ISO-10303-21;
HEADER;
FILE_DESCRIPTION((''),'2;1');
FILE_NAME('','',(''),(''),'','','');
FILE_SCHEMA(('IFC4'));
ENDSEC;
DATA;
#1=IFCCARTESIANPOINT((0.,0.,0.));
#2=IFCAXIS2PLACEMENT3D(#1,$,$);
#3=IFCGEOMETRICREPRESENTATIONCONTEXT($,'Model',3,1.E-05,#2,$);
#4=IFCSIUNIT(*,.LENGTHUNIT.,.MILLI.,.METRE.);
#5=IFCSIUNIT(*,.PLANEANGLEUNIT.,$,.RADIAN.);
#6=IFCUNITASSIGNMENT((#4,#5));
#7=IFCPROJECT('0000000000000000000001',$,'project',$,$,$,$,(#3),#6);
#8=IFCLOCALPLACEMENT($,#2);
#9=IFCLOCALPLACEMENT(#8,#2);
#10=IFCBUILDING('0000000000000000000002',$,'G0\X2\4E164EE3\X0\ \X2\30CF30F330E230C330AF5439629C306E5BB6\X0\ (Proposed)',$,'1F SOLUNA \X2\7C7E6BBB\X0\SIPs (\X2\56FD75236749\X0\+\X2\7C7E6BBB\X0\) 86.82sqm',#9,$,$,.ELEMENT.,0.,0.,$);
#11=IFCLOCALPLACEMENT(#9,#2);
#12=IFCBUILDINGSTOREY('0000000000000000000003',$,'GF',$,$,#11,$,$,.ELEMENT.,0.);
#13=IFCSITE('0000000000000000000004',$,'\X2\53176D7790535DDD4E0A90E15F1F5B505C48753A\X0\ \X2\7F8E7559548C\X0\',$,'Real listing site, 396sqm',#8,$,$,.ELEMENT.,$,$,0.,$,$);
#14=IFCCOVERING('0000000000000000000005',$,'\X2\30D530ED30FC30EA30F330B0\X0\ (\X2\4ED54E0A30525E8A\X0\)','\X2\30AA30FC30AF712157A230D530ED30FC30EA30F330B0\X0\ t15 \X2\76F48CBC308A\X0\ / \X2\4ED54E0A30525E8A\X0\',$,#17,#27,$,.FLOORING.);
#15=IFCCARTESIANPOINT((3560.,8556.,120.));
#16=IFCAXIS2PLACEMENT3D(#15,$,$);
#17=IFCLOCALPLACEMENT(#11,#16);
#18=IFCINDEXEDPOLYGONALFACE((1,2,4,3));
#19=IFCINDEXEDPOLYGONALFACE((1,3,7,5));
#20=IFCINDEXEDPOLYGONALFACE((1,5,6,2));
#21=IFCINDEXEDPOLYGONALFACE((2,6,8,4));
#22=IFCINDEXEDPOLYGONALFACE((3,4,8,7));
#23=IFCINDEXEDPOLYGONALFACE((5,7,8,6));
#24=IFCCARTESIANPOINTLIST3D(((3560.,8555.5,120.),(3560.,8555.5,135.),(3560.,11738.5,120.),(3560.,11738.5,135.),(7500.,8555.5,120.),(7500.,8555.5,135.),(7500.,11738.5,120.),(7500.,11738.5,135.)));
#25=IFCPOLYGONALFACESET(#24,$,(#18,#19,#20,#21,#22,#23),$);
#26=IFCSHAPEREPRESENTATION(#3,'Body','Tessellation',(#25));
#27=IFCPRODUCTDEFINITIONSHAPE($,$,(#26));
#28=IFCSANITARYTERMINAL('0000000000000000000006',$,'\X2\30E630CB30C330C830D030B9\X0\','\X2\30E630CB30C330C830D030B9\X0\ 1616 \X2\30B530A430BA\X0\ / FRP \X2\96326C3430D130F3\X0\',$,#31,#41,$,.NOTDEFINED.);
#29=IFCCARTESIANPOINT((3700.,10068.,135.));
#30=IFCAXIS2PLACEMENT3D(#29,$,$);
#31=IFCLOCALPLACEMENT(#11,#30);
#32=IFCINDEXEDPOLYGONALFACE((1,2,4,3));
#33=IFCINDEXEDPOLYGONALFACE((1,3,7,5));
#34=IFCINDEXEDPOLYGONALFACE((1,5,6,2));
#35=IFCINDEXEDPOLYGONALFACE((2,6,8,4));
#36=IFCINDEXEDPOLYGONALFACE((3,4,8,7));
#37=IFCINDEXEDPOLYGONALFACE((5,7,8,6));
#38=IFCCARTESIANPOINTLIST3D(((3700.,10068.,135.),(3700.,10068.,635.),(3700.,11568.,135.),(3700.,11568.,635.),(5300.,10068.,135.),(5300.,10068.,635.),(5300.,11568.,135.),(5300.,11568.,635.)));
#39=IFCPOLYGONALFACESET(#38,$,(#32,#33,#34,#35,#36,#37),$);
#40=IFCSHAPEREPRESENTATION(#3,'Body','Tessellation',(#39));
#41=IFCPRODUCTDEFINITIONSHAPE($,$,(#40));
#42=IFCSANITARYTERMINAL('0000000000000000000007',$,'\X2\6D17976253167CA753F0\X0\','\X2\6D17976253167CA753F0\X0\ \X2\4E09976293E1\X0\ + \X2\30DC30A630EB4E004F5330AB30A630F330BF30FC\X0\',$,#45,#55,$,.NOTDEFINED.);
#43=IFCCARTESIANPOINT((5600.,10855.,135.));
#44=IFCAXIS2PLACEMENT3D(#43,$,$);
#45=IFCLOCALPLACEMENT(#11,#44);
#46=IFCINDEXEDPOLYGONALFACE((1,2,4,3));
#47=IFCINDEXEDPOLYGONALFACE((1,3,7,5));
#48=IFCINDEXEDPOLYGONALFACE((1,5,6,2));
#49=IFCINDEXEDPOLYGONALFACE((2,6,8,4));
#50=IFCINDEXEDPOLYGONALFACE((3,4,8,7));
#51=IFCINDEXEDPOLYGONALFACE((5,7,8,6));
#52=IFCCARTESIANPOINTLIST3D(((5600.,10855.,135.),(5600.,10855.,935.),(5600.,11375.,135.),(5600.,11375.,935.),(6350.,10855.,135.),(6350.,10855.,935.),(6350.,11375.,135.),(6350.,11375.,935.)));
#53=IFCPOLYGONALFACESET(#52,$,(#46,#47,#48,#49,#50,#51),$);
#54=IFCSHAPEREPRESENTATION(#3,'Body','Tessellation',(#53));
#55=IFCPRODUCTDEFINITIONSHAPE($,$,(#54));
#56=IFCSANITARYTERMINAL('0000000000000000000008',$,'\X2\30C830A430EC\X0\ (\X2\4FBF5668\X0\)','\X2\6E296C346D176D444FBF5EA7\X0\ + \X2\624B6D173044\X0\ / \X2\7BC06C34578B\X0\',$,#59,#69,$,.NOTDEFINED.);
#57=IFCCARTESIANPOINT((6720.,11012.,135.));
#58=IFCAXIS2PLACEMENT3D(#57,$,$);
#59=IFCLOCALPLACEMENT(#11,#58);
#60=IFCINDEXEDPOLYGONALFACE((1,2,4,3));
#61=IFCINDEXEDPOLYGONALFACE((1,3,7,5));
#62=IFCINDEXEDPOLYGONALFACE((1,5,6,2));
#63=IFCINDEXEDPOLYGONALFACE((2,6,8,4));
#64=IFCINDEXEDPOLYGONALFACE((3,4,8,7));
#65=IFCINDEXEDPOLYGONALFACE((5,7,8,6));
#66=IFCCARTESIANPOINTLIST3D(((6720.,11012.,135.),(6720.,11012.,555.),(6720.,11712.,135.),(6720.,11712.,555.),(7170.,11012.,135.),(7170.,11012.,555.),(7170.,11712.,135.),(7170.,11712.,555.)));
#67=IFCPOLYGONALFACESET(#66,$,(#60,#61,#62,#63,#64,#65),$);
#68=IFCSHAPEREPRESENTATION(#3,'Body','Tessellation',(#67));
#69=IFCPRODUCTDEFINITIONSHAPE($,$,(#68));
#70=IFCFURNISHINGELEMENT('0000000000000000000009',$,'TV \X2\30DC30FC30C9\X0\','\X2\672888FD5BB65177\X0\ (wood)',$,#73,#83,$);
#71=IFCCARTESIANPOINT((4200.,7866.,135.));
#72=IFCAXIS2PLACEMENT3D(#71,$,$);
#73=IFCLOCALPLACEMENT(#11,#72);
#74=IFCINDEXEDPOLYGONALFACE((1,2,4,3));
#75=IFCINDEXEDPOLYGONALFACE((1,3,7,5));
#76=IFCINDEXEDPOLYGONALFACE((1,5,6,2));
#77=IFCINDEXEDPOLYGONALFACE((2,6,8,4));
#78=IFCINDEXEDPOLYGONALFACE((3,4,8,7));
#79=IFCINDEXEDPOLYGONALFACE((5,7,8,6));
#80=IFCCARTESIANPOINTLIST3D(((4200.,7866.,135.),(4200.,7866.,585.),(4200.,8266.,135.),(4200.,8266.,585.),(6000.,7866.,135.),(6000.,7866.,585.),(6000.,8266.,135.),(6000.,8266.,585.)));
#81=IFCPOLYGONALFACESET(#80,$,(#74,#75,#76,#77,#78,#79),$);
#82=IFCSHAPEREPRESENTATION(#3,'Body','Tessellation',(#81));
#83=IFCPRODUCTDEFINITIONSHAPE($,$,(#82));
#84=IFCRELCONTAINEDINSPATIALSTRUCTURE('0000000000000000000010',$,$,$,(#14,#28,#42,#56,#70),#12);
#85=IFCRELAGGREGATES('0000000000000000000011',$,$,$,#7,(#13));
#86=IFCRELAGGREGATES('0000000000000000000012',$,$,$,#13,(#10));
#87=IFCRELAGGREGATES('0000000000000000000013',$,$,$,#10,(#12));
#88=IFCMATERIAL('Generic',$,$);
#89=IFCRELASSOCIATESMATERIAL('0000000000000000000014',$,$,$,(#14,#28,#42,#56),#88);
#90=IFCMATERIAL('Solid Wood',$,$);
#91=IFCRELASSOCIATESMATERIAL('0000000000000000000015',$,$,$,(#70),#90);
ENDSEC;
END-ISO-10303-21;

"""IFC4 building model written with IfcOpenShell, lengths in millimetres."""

from ifc_helpers import new_model, si_unit, frame, frame_2d, origin, place, context, project, spatial, rectangle, extrude, material, element, save


model = new_model("IFC4")

# Units and contexts
model_context = context("Model", 3, precision=1e-05, world=origin())
ifc_project = project(units=[si_unit("LENGTHUNIT", "METRE", prefix="MILLI"), si_unit("PLANEANGLEUNIT", "RADIAN")], contexts=[model_context])

# Site, building, storey
site_placement = place(None, origin())
site = spatial("IfcSite", under=ifc_project, at=site_placement, Name="北海道川上郡弟子屈町 美留和", ObjectType="Real listing site, 396sqm", CompositionType="ELEMENT", RefElevation=0.0)
building_placement = place(site_placement, origin())
building = spatial("IfcBuilding", under=site, at=building_placement, Name="G0世代 ハンモック吹抜の家 (Proposed)", ObjectType="1F SOLUNA 籾殻SIPs (国産杉+籾殻) 86.82sqm", CompositionType="ELEMENT", ElevationOfRefHeight=0.0, ElevationOfTerrain=0.0)
storey_placement = place(building_placement, origin())
storey = spatial("IfcBuildingStorey", under=building, at=storey_placement, Name="GF", CompositionType="ELEMENT", Elevation=0.0)

# Shared definitions
ifc_material_1 = material(Name="Solid Wood")
ifc_material_2 = material(Name="Generic")

# Covering
covering_placement = place(storey_placement, frame((3560.0, 8556.0, 120.0)))
element("IfcCovering", 1, at=covering_placement, inside=storey, material=ifc_material_2, Name="フローリング (仕上げ床)", Description="オーク無垢フローリング t15 直貼り / 仕上げ床", PredefinedType="FLOORING", context=model_context, shape_type="SweptSolid", body=[
    extrude(rectangle(XDim=3940.0, YDim=3183.0, at=frame_2d((1970.0, 1591.0))), frame((3560.0, 8556.0, 120.0)), (0.0, 0.0, 1.0), 15.0),
])

# Sanitary terminals
sanitary_terminal_1_placement = place(storey_placement, frame((3700.0, 10068.0, 135.0)))
element("IfcSanitaryTerminal", 2, at=sanitary_terminal_1_placement, inside=storey, material=ifc_material_2, Name="ユニットバス", Description="ユニットバス 1616 サイズ / FRP 防水パン", PredefinedType="NOTDEFINED", context=model_context, shape_type="SweptSolid", body=[
    extrude(rectangle(XDim=1600.0, YDim=1500.0, at=frame_2d((800.0, 750.0))), frame((3700.0, 10068.0, 135.0)), (0.0, 0.0, 1.0), 500.0),
])
sanitary_terminal_2_placement = place(storey_placement, frame((5600.0, 10855.0, 135.0)))
element("IfcSanitaryTerminal", 3, at=sanitary_terminal_2_placement, inside=storey, material=ifc_material_2, Name="洗面化粧台", Description="洗面化粧台 三面鏡 + ボウル一体カウンター", PredefinedType="NOTDEFINED", context=model_context, shape_type="SweptSolid", body=[
    extrude(rectangle(XDim=750.0, YDim=520.0, at=frame_2d((375.0, 260.0))), frame((5600.0, 10855.0, 135.0)), (0.0, 0.0, 1.0), 800.0),
])
sanitary_terminal_3_placement = place(storey_placement, frame((6720.0, 11012.0, 135.0)))
element("IfcSanitaryTerminal", 4, at=sanitary_terminal_3_placement, inside=storey, material=ifc_material_2, Name="トイレ (便器)", Description="温水洗浄便座 + 手洗い / 節水型", PredefinedType="NOTDEFINED", context=model_context, shape_type="SweptSolid", body=[
    extrude(rectangle(XDim=450.0, YDim=700.0, at=frame_2d((225.0, 350.0))), frame((6720.0, 11012.0, 135.0)), (0.0, 0.0, 1.0), 420.0),
])

# Furnishing element
furnishing_placement = place(storey_placement, frame((4200.0, 7866.0, 135.0)))
element("IfcFurnishingElement", 5, at=furnishing_placement, inside=storey, material=ifc_material_1, Name="TV ボード", Description="木製家具 (wood)", context=model_context, shape_type="SweptSolid", body=[
    extrude(rectangle(XDim=1800.0, YDim=400.0, at=frame_2d((900.0, 200.0))), frame((4200.0, 7866.0, 135.0)), (0.0, 0.0, 1.0), 450.0),
])

save(model, "model.ifc")
